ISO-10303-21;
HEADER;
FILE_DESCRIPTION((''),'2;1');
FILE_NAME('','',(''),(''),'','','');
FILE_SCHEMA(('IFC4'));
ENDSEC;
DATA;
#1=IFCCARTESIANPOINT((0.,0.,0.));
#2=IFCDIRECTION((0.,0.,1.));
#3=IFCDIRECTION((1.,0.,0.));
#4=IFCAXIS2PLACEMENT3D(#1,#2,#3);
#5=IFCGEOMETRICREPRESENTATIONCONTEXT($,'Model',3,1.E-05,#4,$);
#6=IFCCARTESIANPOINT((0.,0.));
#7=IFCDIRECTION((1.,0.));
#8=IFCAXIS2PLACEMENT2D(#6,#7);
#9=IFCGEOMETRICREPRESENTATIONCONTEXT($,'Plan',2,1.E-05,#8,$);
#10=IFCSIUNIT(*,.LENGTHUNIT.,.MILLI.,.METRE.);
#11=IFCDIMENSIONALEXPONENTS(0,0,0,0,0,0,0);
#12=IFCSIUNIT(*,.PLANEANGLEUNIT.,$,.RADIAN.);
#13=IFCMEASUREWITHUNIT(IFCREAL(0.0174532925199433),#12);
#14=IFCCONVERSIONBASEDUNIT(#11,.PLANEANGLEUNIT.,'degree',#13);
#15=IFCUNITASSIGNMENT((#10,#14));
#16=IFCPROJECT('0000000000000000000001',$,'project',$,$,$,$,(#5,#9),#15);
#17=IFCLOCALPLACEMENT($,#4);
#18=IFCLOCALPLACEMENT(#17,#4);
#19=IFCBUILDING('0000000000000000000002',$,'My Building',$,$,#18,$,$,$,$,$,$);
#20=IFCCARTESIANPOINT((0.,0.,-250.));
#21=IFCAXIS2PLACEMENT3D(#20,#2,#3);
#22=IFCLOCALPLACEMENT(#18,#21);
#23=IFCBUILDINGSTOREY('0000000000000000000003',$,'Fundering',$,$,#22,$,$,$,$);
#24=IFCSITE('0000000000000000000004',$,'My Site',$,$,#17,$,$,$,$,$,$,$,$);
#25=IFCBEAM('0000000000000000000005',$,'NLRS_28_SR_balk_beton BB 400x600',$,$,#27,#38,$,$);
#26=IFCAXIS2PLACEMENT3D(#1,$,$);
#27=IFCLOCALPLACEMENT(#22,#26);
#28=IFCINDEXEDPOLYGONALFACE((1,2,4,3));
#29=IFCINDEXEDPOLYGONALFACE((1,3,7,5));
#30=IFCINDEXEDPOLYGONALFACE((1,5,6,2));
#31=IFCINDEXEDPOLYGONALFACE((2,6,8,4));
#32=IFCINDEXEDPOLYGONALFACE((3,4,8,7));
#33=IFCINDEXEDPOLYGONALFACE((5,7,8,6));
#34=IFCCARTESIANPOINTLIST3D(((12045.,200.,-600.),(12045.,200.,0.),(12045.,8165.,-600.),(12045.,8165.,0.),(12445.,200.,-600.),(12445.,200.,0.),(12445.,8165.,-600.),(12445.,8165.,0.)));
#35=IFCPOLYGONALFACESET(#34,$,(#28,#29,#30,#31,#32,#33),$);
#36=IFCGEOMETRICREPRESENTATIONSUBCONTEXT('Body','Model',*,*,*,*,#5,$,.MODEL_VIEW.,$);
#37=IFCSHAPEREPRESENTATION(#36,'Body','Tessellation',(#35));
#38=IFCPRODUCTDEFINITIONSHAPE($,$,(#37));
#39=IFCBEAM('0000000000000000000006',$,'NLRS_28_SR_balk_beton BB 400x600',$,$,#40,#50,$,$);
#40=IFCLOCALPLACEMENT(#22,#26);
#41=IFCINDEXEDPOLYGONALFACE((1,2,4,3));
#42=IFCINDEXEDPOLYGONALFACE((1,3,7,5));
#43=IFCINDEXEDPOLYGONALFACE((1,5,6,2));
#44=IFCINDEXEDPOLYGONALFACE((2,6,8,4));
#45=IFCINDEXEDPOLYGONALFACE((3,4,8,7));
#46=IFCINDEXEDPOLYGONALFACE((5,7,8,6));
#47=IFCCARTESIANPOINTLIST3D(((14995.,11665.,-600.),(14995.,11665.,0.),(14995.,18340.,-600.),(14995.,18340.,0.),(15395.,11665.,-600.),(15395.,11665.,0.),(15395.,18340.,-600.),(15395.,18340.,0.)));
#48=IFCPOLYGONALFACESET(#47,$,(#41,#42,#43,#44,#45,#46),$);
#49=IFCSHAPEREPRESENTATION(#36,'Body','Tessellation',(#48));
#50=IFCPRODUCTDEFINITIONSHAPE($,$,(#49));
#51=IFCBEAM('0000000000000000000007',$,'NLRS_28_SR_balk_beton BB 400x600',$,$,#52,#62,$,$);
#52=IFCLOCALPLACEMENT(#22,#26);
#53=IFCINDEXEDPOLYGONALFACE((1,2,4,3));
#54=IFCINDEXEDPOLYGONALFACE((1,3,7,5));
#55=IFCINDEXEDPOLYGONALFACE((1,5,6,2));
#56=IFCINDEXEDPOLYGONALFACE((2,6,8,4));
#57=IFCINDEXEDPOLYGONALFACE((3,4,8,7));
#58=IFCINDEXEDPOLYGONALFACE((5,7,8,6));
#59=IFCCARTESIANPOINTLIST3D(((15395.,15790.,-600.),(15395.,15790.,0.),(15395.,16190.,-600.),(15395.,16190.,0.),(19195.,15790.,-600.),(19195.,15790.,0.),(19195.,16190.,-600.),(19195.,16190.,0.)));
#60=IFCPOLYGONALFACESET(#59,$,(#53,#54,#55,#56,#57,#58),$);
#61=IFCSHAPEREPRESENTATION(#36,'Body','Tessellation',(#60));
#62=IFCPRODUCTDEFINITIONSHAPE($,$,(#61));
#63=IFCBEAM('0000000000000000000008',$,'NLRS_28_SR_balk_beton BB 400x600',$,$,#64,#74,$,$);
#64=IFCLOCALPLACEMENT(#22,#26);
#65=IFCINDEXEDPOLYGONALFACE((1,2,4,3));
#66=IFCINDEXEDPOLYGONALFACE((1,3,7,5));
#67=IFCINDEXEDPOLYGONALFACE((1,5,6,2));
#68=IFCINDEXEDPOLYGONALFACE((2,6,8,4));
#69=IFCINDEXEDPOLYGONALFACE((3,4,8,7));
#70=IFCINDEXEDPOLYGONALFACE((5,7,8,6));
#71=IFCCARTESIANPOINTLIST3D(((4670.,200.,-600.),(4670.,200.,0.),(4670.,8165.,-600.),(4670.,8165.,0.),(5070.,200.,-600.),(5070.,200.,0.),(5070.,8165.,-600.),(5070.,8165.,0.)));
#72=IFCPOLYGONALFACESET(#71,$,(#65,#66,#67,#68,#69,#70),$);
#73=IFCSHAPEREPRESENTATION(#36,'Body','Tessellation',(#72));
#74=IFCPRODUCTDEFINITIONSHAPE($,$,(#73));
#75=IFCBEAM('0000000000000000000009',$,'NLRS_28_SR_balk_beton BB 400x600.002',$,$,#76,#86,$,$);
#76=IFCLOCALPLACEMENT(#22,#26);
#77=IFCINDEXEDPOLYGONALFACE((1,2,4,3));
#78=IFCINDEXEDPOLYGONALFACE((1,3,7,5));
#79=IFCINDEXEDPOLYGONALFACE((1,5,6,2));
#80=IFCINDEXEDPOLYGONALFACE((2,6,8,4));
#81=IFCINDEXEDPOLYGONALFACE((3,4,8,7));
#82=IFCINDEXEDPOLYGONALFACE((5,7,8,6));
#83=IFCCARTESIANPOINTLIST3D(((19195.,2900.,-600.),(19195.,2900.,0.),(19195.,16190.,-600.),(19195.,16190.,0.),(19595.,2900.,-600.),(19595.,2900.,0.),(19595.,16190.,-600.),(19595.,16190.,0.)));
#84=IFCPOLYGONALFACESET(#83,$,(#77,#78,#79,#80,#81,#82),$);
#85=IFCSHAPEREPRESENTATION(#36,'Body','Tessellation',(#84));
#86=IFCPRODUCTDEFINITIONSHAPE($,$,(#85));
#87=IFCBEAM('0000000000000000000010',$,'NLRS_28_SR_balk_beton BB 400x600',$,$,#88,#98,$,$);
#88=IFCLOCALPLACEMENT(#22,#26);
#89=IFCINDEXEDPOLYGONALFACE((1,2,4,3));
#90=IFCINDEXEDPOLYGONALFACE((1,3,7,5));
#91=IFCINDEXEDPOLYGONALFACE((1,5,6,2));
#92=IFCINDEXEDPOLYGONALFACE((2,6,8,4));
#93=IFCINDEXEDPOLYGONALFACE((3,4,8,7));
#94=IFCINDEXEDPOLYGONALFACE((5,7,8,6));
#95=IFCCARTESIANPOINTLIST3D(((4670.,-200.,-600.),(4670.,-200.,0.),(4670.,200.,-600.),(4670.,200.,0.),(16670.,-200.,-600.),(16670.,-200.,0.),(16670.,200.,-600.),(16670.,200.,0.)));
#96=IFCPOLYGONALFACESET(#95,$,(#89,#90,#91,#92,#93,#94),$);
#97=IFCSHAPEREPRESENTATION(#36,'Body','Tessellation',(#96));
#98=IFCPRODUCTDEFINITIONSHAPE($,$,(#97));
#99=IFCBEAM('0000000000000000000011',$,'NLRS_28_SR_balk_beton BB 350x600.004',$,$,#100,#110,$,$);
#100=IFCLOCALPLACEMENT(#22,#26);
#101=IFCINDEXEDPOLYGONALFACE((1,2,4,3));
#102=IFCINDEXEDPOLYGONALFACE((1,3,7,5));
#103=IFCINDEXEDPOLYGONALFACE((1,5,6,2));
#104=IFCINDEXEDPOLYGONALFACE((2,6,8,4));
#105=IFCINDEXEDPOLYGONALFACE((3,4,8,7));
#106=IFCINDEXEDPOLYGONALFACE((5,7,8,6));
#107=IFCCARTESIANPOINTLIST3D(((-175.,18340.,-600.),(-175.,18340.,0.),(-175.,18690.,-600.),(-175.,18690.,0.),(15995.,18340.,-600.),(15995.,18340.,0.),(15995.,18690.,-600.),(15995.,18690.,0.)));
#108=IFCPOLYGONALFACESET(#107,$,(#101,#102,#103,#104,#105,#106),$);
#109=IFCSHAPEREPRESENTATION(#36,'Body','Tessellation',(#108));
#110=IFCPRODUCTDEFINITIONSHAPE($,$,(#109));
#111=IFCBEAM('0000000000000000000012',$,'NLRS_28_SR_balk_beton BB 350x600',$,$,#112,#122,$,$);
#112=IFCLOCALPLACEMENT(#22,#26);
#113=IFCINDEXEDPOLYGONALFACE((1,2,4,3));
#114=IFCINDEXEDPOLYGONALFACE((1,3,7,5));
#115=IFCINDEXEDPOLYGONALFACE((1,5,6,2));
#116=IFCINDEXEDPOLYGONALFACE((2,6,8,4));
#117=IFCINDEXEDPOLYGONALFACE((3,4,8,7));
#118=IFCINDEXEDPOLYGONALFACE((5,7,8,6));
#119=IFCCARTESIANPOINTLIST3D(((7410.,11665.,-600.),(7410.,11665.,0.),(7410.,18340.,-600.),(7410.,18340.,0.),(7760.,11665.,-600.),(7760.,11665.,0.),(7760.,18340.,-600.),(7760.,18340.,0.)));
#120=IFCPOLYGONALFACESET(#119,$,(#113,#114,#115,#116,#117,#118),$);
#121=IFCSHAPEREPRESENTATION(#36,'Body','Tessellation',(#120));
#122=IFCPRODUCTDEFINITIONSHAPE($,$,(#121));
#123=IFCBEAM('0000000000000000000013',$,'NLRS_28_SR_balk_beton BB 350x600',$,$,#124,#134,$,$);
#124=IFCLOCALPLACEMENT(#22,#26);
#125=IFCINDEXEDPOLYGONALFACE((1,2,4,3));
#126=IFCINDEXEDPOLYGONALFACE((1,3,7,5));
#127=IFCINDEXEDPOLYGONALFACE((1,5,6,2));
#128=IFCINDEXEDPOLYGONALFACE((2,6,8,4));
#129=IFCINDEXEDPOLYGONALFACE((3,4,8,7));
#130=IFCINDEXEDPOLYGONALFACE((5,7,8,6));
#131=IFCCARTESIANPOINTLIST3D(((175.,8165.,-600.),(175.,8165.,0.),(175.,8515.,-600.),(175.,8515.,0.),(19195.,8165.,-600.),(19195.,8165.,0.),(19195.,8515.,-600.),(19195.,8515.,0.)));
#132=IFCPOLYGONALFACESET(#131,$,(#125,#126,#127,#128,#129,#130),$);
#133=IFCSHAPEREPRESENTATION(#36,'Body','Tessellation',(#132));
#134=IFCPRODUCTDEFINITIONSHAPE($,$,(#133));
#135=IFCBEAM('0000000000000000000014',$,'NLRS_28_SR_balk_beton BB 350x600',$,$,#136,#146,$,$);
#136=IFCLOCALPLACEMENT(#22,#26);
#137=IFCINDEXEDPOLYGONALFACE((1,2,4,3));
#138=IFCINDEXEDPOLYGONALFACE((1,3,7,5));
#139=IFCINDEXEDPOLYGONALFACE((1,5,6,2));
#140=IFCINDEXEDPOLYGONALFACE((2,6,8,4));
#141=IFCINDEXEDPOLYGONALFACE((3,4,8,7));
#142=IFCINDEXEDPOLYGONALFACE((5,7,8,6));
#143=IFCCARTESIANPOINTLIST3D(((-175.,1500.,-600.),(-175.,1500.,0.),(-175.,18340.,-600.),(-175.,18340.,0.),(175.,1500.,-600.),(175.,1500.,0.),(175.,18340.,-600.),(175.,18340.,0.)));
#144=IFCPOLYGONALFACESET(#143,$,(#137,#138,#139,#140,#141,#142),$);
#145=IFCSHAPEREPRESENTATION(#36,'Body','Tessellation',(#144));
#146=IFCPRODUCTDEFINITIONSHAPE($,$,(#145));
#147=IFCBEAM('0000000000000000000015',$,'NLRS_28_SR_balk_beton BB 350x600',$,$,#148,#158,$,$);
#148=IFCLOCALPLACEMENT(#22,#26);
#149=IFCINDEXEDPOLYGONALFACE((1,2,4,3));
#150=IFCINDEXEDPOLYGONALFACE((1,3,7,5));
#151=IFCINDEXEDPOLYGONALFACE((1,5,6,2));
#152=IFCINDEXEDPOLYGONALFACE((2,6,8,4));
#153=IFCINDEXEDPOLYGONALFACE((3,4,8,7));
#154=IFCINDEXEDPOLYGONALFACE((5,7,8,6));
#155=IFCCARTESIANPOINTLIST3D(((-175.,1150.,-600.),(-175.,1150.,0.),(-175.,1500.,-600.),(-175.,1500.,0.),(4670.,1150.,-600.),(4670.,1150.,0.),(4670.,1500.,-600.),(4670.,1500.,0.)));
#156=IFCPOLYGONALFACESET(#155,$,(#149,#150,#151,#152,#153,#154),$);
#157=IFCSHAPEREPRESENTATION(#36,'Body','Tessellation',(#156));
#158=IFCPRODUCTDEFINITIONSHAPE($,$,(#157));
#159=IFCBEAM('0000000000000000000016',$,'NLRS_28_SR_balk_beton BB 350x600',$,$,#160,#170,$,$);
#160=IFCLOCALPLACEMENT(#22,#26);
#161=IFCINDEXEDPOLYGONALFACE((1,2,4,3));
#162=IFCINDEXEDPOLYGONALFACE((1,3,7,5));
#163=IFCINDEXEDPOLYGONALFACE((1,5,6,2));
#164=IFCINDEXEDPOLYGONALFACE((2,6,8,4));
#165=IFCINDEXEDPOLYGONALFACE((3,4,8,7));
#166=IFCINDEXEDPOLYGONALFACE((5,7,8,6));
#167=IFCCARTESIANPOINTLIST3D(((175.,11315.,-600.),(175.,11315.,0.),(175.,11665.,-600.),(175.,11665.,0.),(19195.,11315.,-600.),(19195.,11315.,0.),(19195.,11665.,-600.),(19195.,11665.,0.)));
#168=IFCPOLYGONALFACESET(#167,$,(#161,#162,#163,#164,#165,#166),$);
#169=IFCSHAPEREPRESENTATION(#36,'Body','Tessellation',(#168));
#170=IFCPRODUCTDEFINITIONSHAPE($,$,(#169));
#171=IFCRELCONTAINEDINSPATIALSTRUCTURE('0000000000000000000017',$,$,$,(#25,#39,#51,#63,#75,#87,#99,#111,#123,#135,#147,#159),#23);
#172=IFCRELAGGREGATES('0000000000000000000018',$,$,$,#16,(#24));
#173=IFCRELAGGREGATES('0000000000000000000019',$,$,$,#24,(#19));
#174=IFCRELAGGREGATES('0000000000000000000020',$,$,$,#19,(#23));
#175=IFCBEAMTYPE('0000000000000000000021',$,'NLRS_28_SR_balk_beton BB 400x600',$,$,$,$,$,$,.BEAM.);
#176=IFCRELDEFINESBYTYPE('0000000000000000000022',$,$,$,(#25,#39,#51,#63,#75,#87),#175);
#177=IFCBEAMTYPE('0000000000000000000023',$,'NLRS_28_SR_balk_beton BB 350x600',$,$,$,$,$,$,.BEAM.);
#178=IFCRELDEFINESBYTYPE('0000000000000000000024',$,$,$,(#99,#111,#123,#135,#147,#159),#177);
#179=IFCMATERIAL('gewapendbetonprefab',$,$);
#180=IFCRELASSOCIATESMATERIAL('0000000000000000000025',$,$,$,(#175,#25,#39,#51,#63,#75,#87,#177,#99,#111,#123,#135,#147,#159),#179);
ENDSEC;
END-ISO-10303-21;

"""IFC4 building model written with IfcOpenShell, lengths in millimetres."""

from ifc_helpers import new_model, entity, si_unit, converted_unit, frame, origin_with_axes, origin_2d_with_axis, place, context, subcontext, project, spatial, rectangle, extrude, material, material_profile, profile_set, profile_usage, type_object, element, save


model = new_model("IFC4")

# Units and contexts
model_context = context("Model", 3, precision=1e-05, world=origin_with_axes())
plan_context = context("Plan", 2, precision=1e-05, world=origin_2d_with_axis())
body_context = subcontext(model_context, "Body", "Model", "MODEL_VIEW")
ifc_project = project(units=[si_unit("LENGTHUNIT", "METRE", prefix="MILLI"), converted_unit("PLANEANGLEUNIT", "degree", entity("IfcReal", 0.0174532925199433), si_unit("PLANEANGLEUNIT", "RADIAN"), dimensions=[0, 0, 0, 0, 0, 0, 0])], contexts=[model_context, plan_context])

# Site, building, storey
site_placement = place(None, origin_with_axes())
site = spatial("IfcSite", under=ifc_project, at=site_placement, Name="My Site")
building_placement = place(site_placement, origin_with_axes())
building = spatial("IfcBuilding", under=site, at=building_placement, Name="My Building")
storey_placement = place(building_placement, frame((0.0, 0.0, -250.0), z_axis=(0.0, 0.0, 1.0), x_axis=(1.0, 0.0, 0.0)))
storey = spatial("IfcBuildingStorey", under=building, at=storey_placement, Name="Fundering")

# Beams
ifc_material = material(Name="gewapendbetonprefab")
ifc_material_profile_1 = material_profile(ifc_material, rectangle(XDim=400.0, YDim=600.0))
ifc_profile_set_1 = profile_set([ifc_material_profile_1], Name="NLRS_28_SR_balk_beton BB 400x600")
ifc_profile_usage_1 = profile_usage(ifc_profile_set_1, cardinal=8)
beam_type_1 = type_object("IfcBeamType", Name="NLRS_28_SR_balk_beton BB 400x600", PredefinedType="BEAM", material=ifc_profile_set_1)
beam_1_placement = place(storey_placement, frame((12245.0, 200.0, 0.0), z_axis=(0.0, 1.0, 0.0), x_axis=(-1.0, 0.0, 0.0)))
element("IfcBeam", 1, at=beam_1_placement, inside=storey, type_object=beam_type_1, material=ifc_profile_usage_1, Name="NLRS_28_SR_balk_beton BB 400x600", context=body_context, shape_type="SweptSolid", body=[
    extrude(rectangle(XDim=400.0, YDim=600.0), frame((0.0, -300.0, 0.0), z_axis=(0.0, 0.0, 1.0), x_axis=(1.0, 0.0, 0.0)), (0.0, 0.0, 1.0), 7965.0),
])
ifc_profile_usage_2 = profile_usage(ifc_profile_set_1, cardinal=8)
beam_2_placement = place(storey_placement, frame((15195.0, 11665.0, 0.0), z_axis=(0.0, 1.0, 0.0), x_axis=(-1.0, 0.0, 0.0)))
element("IfcBeam", 2, at=beam_2_placement, inside=storey, type_object=beam_type_1, material=ifc_profile_usage_2, Name="NLRS_28_SR_balk_beton BB 400x600", context=body_context, shape_type="SweptSolid", body=[
    extrude(rectangle(XDim=400.0, YDim=600.0), frame((0.0, -300.0, 0.0), z_axis=(0.0, 0.0, 1.0), x_axis=(1.0, 0.0, 0.0)), (0.0, 0.0, 1.0), 6675.0),
])
ifc_profile_usage_3 = profile_usage(ifc_profile_set_1, cardinal=8)
beam_3_placement = place(storey_placement, frame((19195.0, 15990.0, 0.0), z_axis=(-1.0, 0.0, 0.0), x_axis=(0.0, -1.0, 0.0)))
element("IfcBeam", 3, at=beam_3_placement, inside=storey, type_object=beam_type_1, material=ifc_profile_usage_3, Name="NLRS_28_SR_balk_beton BB 400x600", context=body_context, shape_type="SweptSolid", body=[
    extrude(rectangle(XDim=400.0, YDim=600.0), frame((0.0, -300.0, 0.0), z_axis=(0.0, 0.0, 1.0), x_axis=(1.0, 0.0, 0.0)), (0.0, 0.0, 1.0), 3800.0),
])
ifc_profile_usage_4 = profile_usage(ifc_profile_set_1, cardinal=8)
beam_4_placement = place(storey_placement, frame((4870.0, 200.0, 0.0), z_axis=(0.0, 1.0, 0.0), x_axis=(-1.0, 0.0, 0.0)))
element("IfcBeam", 4, at=beam_4_placement, inside=storey, type_object=beam_type_1, material=ifc_profile_usage_4, Name="NLRS_28_SR_balk_beton BB 400x600", context=body_context, shape_type="SweptSolid", body=[
    extrude(rectangle(XDim=400.0, YDim=600.0), frame((0.0, -300.0, 0.0), z_axis=(0.0, 0.0, 1.0), x_axis=(1.0, 0.0, 0.0)), (0.0, 0.0, 1.0), 7965.0),
])
ifc_profile_usage_5 = profile_usage(ifc_profile_set_1, cardinal=8)
beam_5_placement = place(storey_placement, frame((19395.0, 2900.0, 0.0), z_axis=(0.0, 1.0, 0.0), x_axis=(-1.0, 0.0, 0.0)))
element("IfcBeam", 5, at=beam_5_placement, inside=storey, type_object=beam_type_1, material=ifc_profile_usage_5, Name="NLRS_28_SR_balk_beton BB 400x600.002", context=body_context, shape_type="SweptSolid", body=[
    extrude(rectangle(XDim=400.0, YDim=600.0), frame((0.0, -300.0, 0.0), z_axis=(0.0, 0.0, 1.0), x_axis=(1.0, 0.0, 0.0)), (0.0, 0.0, 1.0), 13290.0),
])
ifc_profile_usage_6 = profile_usage(ifc_profile_set_1, cardinal=8)
beam_6_placement = place(storey_placement, frame((4670.0, 0.0, 0.0), z_axis=(1.0, 0.0, 0.0), x_axis=(0.0, 1.0, 0.0)))
element("IfcBeam", 6, at=beam_6_placement, inside=storey, type_object=beam_type_1, material=ifc_profile_usage_6, Name="NLRS_28_SR_balk_beton BB 400x600", context=body_context, shape_type="SweptSolid", body=[
    extrude(rectangle(XDim=400.0, YDim=600.0), frame((0.0, -300.0, 0.0), z_axis=(0.0, 0.0, 1.0), x_axis=(1.0, 0.0, 0.0)), (0.0, 0.0, 1.0), 12000.0),
])
ifc_material_profile_2 = material_profile(ifc_material, rectangle(XDim=350.0, YDim=600.0))
ifc_profile_set_2 = profile_set([ifc_material_profile_2], Name="NLRS_28_SR_balk_beton BB 350x600")
ifc_profile_usage_7 = profile_usage(ifc_profile_set_2, cardinal=8)
beam_type_2 = type_object("IfcBeamType", Name="NLRS_28_SR_balk_beton BB 350x600", PredefinedType="BEAM", material=ifc_profile_set_2)
beam_7_placement = place(storey_placement, frame((-175.0, 18515.0, 0.0), z_axis=(1.0, 0.0, 0.0), x_axis=(0.0, 1.0, 0.0)))
element("IfcBeam", 7, at=beam_7_placement, inside=storey, type_object=beam_type_2, material=ifc_profile_usage_7, Name="NLRS_28_SR_balk_beton BB 350x600.004", context=body_context, shape_type="SweptSolid", body=[
    extrude(rectangle(XDim=350.0, YDim=600.0), frame((0.0, -300.0, 0.0)), (0.0, 0.0, 1.0), 16170.0),
])
ifc_profile_usage_8 = profile_usage(ifc_profile_set_2, cardinal=8)
beam_8_placement = place(storey_placement, frame((7585.0, 11665.0, 0.0), z_axis=(0.0, 1.0, 0.0), x_axis=(-1.0, 0.0, 0.0)))
element("IfcBeam", 8, at=beam_8_placement, inside=storey, type_object=beam_type_2, material=ifc_profile_usage_8, Name="NLRS_28_SR_balk_beton BB 350x600", context=body_context, shape_type="SweptSolid", body=[
    extrude(rectangle(XDim=350.0, YDim=600.0), frame((0.0, -300.0, 0.0), z_axis=(0.0, 0.0, 1.0), x_axis=(1.0, 0.0, 0.0)), (0.0, 0.0, 1.0), 6675.0),
])
ifc_profile_usage_9 = profile_usage(ifc_profile_set_2, cardinal=8)
beam_9_placement = place(storey_placement, frame((19195.0, 8340.0, 0.0), z_axis=(-1.0, 0.0, 0.0), x_axis=(0.0, -1.0, 0.0)))
element("IfcBeam", 9, at=beam_9_placement, inside=storey, type_object=beam_type_2, material=ifc_profile_usage_9, Name="NLRS_28_SR_balk_beton BB 350x600", context=body_context, shape_type="SweptSolid", body=[
    extrude(rectangle(XDim=350.0, YDim=600.0), frame((0.0, -300.0, 0.0), z_axis=(0.0, 0.0, 1.0), x_axis=(1.0, 0.0, 0.0)), (0.0, 0.0, 1.0), 19020.0),
])
ifc_profile_usage_10 = profile_usage(ifc_profile_set_2, cardinal=8)
beam_10_placement = place(storey_placement, frame((0.0, 1500.0, 0.0), z_axis=(0.0, 1.0, 0.0), x_axis=(-1.0, 0.0, 0.0)))
element("IfcBeam", 10, at=beam_10_placement, inside=storey, type_object=beam_type_2, material=ifc_profile_usage_10, Name="NLRS_28_SR_balk_beton BB 350x600", context=body_context, shape_type="SweptSolid", body=[
    extrude(rectangle(XDim=350.0, YDim=600.0), frame((0.0, -300.0, 0.0), z_axis=(0.0, 0.0, 1.0), x_axis=(1.0, 0.0, 0.0)), (0.0, 0.0, 1.0), 16840.0),
])
ifc_profile_usage_11 = profile_usage(ifc_profile_set_2, cardinal=8)
beam_11_placement = place(storey_placement, frame((4670.0, 1325.0, 0.0), z_axis=(-1.0, 0.0, 0.0), x_axis=(0.0, -1.0, 0.0)))
element("IfcBeam", 11, at=beam_11_placement, inside=storey, type_object=beam_type_2, material=ifc_profile_usage_11, Name="NLRS_28_SR_balk_beton BB 350x600", context=body_context, shape_type="SweptSolid", body=[
    extrude(rectangle(XDim=350.0, YDim=600.0), frame((0.0, -300.0, 0.0), z_axis=(0.0, 0.0, 1.0), x_axis=(1.0, 0.0, 0.0)), (0.0, 0.0, 1.0), 4845.0),
])
ifc_profile_usage_12 = profile_usage(ifc_profile_set_2, cardinal=8)
beam_12_placement = place(storey_placement, frame((19195.0, 11490.0, 0.0), z_axis=(-1.0, 0.0, 0.0), x_axis=(0.0, -1.0, 0.0)))
element("IfcBeam", 12, at=beam_12_placement, inside=storey, type_object=beam_type_2, material=ifc_profile_usage_12, Name="NLRS_28_SR_balk_beton BB 350x600", context=body_context, shape_type="SweptSolid", body=[
    extrude(rectangle(XDim=350.0, YDim=600.0), frame((0.0, -300.0, 0.0), z_axis=(0.0, 0.0, 1.0), x_axis=(1.0, 0.0, 0.0)), (0.0, 0.0, 1.0), 19020.0),
])

save(model, "model.ifc")
